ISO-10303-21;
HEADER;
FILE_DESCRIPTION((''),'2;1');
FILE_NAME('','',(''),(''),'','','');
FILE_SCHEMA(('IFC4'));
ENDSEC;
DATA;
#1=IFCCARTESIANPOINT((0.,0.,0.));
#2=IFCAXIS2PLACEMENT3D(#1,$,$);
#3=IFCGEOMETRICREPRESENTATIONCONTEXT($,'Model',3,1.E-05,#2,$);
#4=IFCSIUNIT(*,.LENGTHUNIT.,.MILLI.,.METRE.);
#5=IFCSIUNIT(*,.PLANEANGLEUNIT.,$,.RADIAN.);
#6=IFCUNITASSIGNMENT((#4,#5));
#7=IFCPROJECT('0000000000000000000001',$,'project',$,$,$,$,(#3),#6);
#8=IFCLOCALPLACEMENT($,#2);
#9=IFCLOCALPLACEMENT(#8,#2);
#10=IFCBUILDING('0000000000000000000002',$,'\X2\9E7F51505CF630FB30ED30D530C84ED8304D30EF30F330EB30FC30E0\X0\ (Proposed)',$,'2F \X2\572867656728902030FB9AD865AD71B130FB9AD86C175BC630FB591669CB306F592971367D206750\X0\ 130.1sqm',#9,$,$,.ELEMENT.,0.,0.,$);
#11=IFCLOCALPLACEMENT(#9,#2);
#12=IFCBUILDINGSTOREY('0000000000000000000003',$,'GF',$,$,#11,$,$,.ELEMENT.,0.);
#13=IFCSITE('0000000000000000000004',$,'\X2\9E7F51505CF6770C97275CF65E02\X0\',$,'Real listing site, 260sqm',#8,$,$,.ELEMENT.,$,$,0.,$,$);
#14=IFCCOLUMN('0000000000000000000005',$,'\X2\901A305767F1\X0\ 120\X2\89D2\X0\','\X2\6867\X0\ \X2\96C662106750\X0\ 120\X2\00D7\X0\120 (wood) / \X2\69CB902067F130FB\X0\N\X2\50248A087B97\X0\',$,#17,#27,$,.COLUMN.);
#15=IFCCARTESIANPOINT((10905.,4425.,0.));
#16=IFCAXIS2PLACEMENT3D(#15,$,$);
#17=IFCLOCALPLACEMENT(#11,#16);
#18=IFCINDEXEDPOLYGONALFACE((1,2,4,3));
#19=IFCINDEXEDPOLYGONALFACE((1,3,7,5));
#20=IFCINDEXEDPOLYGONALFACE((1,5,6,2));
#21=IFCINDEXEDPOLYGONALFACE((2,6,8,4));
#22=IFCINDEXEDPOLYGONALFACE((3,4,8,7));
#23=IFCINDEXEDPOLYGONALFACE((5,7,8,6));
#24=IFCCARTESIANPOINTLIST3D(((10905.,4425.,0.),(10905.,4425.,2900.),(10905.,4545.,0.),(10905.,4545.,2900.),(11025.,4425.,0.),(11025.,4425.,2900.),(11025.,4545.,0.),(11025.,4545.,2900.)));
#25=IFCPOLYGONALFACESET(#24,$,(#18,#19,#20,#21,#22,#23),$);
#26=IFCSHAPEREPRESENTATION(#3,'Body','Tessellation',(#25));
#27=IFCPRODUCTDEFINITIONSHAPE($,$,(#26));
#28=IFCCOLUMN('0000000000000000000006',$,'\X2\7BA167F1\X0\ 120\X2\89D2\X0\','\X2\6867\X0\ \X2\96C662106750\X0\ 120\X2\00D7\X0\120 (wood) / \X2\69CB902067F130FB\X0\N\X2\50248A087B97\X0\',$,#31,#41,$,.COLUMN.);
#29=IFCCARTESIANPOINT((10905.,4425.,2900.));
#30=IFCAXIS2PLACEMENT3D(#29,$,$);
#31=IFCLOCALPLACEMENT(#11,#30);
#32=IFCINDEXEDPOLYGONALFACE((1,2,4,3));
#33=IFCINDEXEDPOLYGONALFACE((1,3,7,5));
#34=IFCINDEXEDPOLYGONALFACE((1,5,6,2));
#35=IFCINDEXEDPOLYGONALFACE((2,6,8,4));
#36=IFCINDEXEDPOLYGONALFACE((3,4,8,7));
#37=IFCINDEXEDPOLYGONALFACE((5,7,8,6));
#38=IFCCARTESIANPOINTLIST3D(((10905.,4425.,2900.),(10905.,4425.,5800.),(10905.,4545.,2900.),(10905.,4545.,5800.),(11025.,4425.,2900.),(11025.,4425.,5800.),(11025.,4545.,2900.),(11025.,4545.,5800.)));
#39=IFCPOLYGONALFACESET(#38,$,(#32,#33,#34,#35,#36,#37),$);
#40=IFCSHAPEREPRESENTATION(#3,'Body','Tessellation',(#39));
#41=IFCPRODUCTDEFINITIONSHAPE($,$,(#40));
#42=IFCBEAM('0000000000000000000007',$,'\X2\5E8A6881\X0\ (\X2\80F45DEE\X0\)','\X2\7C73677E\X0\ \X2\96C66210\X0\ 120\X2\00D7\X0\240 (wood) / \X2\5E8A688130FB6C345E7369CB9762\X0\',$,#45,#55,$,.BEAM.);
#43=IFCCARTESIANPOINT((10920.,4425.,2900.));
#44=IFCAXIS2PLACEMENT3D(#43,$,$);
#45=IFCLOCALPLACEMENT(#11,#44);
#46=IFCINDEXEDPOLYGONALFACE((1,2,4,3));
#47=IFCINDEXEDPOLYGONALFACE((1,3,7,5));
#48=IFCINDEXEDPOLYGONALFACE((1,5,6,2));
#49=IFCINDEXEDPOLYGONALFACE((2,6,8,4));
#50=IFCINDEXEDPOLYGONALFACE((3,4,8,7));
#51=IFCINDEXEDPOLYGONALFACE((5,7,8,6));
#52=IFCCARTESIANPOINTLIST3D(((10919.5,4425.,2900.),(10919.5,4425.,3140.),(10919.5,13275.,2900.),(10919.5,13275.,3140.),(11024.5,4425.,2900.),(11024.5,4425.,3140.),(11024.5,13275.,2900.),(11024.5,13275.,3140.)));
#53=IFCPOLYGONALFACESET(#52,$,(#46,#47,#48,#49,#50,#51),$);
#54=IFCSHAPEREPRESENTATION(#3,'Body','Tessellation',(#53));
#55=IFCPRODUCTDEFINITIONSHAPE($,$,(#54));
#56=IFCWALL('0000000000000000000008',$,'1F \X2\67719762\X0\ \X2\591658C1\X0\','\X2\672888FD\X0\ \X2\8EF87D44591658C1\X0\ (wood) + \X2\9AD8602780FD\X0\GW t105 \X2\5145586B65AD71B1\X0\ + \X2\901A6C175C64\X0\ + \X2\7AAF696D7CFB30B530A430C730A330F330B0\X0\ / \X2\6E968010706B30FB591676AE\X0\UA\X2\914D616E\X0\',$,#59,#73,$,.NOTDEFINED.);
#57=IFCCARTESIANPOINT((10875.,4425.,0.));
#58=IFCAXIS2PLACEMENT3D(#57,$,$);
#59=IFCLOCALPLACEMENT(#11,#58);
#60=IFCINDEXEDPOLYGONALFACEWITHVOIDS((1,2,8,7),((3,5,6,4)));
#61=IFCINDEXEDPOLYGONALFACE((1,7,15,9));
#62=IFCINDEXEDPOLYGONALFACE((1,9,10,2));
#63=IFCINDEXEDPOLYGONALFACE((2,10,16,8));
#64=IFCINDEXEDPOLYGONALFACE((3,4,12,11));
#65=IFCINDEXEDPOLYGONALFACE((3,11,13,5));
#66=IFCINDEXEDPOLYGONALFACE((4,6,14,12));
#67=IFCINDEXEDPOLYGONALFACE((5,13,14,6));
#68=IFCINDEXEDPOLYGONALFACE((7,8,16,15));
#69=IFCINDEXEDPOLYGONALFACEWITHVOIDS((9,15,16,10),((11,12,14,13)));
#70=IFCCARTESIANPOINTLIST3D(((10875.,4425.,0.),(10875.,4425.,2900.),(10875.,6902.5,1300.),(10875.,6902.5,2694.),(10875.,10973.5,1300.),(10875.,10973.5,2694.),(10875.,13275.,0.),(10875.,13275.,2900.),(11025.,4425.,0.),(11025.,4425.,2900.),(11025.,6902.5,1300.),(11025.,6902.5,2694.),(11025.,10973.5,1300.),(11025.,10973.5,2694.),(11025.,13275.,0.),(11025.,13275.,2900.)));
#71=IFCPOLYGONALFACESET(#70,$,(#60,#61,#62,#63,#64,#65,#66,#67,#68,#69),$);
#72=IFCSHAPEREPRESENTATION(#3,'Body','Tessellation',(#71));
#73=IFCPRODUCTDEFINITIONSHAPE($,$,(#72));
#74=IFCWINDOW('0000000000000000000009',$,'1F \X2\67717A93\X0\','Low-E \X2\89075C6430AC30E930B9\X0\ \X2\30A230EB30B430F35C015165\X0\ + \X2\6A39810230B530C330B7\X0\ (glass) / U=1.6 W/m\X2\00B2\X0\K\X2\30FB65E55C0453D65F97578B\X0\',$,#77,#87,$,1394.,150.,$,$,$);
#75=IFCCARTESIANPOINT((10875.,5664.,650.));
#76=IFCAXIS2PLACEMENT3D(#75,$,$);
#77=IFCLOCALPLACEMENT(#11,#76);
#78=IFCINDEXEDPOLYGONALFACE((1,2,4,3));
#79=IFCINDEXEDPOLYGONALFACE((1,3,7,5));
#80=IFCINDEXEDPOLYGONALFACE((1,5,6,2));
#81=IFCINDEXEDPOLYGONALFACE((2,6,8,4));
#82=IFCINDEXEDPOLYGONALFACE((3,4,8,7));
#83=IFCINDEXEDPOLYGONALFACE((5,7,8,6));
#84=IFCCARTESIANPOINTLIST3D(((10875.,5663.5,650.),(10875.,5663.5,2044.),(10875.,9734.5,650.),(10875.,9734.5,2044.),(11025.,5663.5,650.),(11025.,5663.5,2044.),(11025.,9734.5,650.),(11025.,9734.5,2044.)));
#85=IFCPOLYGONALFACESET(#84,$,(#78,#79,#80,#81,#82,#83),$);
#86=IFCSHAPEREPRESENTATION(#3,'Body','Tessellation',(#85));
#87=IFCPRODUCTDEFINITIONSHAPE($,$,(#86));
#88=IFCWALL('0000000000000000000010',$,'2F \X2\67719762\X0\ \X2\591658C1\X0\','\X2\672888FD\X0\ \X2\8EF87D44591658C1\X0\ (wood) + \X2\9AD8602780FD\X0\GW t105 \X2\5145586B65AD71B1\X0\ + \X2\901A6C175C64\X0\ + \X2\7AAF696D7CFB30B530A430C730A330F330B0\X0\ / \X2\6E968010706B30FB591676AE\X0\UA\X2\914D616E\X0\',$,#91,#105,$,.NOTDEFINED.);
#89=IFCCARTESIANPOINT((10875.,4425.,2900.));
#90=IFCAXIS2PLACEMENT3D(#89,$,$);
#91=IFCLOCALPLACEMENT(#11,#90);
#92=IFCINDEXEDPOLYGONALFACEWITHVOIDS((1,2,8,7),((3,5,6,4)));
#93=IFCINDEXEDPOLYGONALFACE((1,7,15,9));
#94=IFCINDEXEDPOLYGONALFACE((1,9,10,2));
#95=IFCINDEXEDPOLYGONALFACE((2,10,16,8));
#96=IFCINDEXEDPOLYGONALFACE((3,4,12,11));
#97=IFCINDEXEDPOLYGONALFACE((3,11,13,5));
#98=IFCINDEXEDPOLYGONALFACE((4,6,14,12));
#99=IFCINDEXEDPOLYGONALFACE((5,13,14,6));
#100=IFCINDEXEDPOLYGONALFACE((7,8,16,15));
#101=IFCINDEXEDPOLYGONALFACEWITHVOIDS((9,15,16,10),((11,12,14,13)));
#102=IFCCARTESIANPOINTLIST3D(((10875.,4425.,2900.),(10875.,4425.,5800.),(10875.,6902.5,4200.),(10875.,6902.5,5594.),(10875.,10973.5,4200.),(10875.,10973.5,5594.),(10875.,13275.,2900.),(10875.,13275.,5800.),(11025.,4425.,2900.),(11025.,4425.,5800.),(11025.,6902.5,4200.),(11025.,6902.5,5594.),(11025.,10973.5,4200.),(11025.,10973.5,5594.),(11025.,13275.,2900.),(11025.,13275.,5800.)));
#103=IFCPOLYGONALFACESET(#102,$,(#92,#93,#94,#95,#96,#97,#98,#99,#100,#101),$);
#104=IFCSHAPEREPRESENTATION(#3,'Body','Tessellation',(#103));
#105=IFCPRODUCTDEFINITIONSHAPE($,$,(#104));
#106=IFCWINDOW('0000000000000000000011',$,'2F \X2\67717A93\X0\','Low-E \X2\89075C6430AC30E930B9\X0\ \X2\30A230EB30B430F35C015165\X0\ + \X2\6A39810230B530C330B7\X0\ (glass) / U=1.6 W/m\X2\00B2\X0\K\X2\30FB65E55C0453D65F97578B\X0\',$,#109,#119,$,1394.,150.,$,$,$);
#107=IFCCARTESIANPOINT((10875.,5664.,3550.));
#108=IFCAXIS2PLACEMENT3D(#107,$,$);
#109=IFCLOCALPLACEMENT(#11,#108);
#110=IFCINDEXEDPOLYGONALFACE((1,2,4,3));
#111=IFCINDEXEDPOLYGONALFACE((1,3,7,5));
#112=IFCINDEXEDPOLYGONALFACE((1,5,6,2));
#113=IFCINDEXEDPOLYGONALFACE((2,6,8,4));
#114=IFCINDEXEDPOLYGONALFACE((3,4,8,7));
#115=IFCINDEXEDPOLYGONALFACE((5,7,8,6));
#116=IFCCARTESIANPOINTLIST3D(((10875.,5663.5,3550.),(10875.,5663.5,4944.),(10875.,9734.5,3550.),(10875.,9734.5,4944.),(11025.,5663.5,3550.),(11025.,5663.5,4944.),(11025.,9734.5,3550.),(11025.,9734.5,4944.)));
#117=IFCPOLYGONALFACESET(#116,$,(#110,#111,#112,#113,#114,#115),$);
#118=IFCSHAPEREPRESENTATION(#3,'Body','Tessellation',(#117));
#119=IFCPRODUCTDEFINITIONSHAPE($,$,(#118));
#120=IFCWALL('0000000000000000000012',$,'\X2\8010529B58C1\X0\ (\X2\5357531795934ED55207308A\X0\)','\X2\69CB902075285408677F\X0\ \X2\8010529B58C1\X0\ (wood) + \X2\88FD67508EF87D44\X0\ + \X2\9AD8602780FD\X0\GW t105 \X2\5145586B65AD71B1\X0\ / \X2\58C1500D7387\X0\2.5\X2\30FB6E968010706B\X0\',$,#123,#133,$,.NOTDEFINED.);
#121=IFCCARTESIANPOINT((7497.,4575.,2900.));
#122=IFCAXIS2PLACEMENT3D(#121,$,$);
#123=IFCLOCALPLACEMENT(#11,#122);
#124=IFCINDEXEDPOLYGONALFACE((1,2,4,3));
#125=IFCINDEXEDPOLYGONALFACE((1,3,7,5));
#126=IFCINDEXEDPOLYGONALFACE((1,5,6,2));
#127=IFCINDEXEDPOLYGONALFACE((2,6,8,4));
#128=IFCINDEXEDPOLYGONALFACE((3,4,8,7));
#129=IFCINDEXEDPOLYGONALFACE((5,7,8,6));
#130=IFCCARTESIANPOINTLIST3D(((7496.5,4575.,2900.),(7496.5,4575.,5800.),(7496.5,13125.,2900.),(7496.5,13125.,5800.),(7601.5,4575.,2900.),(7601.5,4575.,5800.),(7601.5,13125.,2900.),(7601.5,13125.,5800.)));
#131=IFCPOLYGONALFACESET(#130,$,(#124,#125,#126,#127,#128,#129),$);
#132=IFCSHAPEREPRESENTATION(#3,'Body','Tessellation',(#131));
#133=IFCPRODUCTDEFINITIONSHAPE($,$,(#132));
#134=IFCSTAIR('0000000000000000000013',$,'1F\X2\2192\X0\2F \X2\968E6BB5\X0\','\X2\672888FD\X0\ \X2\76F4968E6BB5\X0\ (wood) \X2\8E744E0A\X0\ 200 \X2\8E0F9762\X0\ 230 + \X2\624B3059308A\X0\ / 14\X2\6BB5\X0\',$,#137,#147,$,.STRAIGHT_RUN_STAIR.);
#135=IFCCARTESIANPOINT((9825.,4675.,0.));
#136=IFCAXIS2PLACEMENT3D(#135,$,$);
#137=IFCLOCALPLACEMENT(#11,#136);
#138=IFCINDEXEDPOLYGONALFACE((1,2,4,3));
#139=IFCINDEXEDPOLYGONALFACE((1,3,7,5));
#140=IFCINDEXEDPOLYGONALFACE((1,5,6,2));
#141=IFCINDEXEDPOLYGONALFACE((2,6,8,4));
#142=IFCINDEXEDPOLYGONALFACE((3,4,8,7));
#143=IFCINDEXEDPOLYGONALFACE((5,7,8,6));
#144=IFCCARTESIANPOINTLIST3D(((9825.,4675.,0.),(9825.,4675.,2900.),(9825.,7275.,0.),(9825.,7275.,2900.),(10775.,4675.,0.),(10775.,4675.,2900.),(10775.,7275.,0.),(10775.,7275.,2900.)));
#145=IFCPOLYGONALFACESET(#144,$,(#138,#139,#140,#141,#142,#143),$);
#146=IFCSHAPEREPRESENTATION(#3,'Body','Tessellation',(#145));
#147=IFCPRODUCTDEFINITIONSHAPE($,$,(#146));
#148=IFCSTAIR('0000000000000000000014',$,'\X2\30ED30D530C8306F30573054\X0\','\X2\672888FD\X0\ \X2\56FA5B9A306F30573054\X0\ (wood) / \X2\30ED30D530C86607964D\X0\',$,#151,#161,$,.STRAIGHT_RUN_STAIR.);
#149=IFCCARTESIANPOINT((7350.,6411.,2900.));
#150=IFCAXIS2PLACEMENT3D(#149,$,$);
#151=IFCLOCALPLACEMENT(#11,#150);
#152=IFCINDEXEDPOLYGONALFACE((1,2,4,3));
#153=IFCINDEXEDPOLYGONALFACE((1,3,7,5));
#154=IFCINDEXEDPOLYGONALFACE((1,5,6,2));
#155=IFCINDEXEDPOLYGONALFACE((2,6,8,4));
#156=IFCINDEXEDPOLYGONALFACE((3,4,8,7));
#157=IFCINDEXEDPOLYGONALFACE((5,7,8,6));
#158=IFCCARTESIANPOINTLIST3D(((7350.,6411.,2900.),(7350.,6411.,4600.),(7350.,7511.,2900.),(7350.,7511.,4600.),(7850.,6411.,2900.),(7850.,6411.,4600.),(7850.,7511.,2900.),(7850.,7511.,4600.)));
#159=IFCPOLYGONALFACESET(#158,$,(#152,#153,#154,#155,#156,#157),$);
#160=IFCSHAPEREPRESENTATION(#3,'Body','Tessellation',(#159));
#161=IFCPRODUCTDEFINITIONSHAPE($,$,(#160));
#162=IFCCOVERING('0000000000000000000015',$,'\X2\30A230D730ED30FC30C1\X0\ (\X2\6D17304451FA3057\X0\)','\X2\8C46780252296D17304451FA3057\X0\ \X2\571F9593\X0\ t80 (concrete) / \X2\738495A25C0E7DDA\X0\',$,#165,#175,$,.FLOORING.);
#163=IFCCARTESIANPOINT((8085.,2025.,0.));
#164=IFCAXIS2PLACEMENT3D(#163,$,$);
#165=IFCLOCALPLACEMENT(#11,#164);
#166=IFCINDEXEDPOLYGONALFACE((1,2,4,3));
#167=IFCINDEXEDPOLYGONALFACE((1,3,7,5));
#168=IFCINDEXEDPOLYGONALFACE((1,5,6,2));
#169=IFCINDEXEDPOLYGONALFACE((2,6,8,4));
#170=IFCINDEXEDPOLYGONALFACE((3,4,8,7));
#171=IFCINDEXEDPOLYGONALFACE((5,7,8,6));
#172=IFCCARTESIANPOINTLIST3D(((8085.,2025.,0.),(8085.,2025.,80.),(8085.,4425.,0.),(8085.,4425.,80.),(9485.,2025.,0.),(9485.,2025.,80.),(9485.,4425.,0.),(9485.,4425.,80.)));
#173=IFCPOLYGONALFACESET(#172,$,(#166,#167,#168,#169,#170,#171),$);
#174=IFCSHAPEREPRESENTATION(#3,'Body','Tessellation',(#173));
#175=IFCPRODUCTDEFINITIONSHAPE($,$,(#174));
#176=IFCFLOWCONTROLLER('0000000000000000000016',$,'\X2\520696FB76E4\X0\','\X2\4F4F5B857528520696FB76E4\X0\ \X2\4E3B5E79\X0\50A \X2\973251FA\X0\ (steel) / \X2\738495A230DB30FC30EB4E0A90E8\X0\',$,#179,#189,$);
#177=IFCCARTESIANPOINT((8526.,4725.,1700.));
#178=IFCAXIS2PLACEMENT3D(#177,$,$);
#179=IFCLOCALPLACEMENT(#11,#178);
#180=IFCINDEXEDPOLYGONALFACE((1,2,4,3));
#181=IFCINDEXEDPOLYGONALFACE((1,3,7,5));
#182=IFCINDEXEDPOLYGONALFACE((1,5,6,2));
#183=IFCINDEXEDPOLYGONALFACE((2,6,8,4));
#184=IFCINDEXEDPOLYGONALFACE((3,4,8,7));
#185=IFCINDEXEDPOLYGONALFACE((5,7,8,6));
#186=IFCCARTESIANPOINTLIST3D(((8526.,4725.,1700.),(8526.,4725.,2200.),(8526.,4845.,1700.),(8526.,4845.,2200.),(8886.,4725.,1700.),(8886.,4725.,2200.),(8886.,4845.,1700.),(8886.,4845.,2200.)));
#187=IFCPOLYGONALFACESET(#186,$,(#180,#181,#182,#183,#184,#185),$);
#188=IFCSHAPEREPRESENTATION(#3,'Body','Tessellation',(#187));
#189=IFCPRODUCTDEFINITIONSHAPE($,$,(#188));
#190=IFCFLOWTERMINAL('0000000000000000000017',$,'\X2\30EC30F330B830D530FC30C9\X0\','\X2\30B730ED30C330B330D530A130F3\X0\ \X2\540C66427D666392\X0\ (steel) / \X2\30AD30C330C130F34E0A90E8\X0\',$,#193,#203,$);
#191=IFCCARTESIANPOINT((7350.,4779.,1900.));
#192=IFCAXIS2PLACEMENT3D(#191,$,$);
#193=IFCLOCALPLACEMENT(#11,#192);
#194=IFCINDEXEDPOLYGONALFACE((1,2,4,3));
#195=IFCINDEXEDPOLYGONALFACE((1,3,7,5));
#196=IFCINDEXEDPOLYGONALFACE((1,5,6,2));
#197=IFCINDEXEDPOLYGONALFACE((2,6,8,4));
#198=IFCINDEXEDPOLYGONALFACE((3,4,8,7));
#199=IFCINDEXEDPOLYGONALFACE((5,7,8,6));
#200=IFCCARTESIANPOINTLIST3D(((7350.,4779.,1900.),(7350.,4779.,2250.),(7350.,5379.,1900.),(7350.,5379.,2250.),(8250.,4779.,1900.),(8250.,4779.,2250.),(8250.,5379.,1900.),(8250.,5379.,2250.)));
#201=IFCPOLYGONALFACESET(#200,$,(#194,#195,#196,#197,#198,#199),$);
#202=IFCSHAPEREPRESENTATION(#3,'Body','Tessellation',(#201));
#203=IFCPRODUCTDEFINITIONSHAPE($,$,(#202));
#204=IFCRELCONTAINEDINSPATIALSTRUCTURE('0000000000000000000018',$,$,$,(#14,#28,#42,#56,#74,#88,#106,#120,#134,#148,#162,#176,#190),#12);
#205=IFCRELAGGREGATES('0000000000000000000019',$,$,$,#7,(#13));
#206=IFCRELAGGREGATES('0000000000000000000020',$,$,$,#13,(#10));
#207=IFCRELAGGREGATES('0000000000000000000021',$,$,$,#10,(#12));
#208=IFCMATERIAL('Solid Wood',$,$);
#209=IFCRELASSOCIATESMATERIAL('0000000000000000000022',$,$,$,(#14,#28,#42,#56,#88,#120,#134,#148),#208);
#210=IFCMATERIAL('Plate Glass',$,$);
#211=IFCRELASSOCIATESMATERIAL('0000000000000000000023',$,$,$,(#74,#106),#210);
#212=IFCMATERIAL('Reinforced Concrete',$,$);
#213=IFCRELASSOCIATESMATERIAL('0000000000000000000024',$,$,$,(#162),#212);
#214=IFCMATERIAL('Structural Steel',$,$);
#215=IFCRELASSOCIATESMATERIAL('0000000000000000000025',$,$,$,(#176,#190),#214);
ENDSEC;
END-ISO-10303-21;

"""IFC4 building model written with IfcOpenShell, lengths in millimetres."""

from ifc_helpers import new_model, si_unit, frame, frame_2d, origin, place, context, project, spatial, rectangle, extrude, material, element, fill, save


model = new_model("IFC4")

# Units and contexts
model_context = context("Model", 3, precision=1e-05, world=origin())
ifc_project = project(units=[si_unit("LENGTHUNIT", "METRE", prefix="MILLI"), si_unit("PLANEANGLEUNIT", "RADIAN")], contexts=[model_context])

# Site, building, storey
site_placement = place(None, origin())
site = spatial("IfcSite", under=ifc_project, at=site_placement, Name="鹿児島県霧島市", ObjectType="Real listing site, 260sqm", CompositionType="ELEMENT", RefElevation=0.0)
building_placement = place(site_placement, origin())
building = spatial("IfcBuilding", under=site, at=building_placement, Name="鹿児島・ロフト付きワンルーム (Proposed)", ObjectType="2F 在来木造・高断熱・高気密・外構は天然素材 130.1sqm", CompositionType="ELEMENT", ElevationOfRefHeight=0.0, ElevationOfTerrain=0.0)
storey_placement = place(building_placement, origin())
storey = spatial("IfcBuildingStorey", under=building, at=storey_placement, Name="GF", CompositionType="ELEMENT", Elevation=0.0)

# Columns
ifc_material_1 = material(Name="Solid Wood")
column_1_placement = place(storey_placement, frame((10905.0, 4425.0, 0.0)))
element("IfcColumn", 1, at=column_1_placement, inside=storey, material=ifc_material_1, Name="通し柱 120角", Description="桧 集成材 120×120 (wood) / 構造柱・N値計算", PredefinedType="COLUMN", context=model_context, shape_type="SweptSolid", body=[
    extrude(rectangle(XDim=120.0, YDim=120.0, at=frame_2d((60.0, 60.0))), frame((10905.0, 4425.0, 0.0)), (0.0, 0.0, 1.0), 2900.0),
])
column_2_placement = place(storey_placement, frame((10905.0, 4425.0, 2900.0)))
element("IfcColumn", 2, at=column_2_placement, inside=storey, material=ifc_material_1, Name="管柱 120角", Description="桧 集成材 120×120 (wood) / 構造柱・N値計算", PredefinedType="COLUMN", context=model_context, shape_type="SweptSolid", body=[
    extrude(rectangle(XDim=120.0, YDim=120.0, at=frame_2d((60.0, 60.0))), frame((10905.0, 4425.0, 2900.0)), (0.0, 0.0, 1.0), 2900.0),
])

# Beam
beam_1_placement = place(storey_placement, frame((10920.0, 4425.0, 2900.0)))
element("IfcBeam", 3, at=beam_1_placement, inside=storey, material=ifc_material_1, Name="床梁 (胴差)", Description="米松 集成 120×240 (wood) / 床梁・水平構面", PredefinedType="BEAM", context=model_context, shape_type="SweptSolid", body=[
    extrude(rectangle(XDim=105.0, YDim=8850.0, at=frame_2d((52.0, 4425.0))), frame((10920.0, 4425.0, 2900.0)), (0.0, 0.0, 1.0), 240.0),
])

# Wall, opening, window
wall_1_placement = place(storey_placement, frame((10875.0, 4425.0, 0.0)))
wall_1 = element("IfcWall", 4, at=wall_1_placement, inside=storey, material=ifc_material_1, Name="1F 東面 外壁", Description="木製 軸組外壁 (wood) + 高性能GW t105 充填断熱 + 通気層 + 窯業系サイディング / 準耐火・外皮UA配慮", PredefinedType="NOTDEFINED", context=model_context, shape_type="SweptSolid", body=[
    extrude(rectangle(XDim=150.0, YDim=8850.0, at=frame_2d((75.0, 4425.0))), frame((10875.0, 4425.0, 0.0)), (0.0, 0.0, 1.0), 2900.0),
])
opening_1_placement = place(storey_placement, frame((10875.0, 5664.0, 650.0)))
opening_1 = element("IfcOpeningElement", 5, at=opening_1_placement, cuts=wall_1, PredefinedType="NOTDEFINED", context=model_context, shape_type="SweptSolid", body=[
    extrude(rectangle(XDim=150.0, YDim=4071.0, at=frame_2d((75.0, 2035.0))), frame((10875.0, 5664.0, 650.0)), (0.0, 0.0, 1.0), 1394.0),
])
ifc_material_2 = material(Name="Plate Glass")
window_1_placement = place(storey_placement, frame((10875.0, 5664.0, 650.0)))
window_1 = element("IfcWindow", 6, at=window_1_placement, inside=storey, material=ifc_material_2, Name="1F 東窓", Description="Low-E 複層ガラス アルゴン封入 + 樹脂サッシ (glass) / U=1.6 W/m²K・日射取得型", OverallHeight=1394.0, OverallWidth=150.0, context=model_context, shape_type="SweptSolid", body=[
    extrude(rectangle(XDim=150.0, YDim=4071.0, at=frame_2d((75.0, 2035.0))), frame((10875.0, 5664.0, 650.0)), (0.0, 0.0, 1.0), 1394.0),
])
fill(opening_1, window_1)

# Wall, opening, window
wall_2_placement = place(storey_placement, frame((10875.0, 4425.0, 2900.0)))
wall_2 = element("IfcWall", 7, at=wall_2_placement, inside=storey, material=ifc_material_1, Name="2F 東面 外壁", Description="木製 軸組外壁 (wood) + 高性能GW t105 充填断熱 + 通気層 + 窯業系サイディング / 準耐火・外皮UA配慮", PredefinedType="NOTDEFINED", context=model_context, shape_type="SweptSolid", body=[
    extrude(rectangle(XDim=150.0, YDim=8850.0, at=frame_2d((75.0, 4425.0))), frame((10875.0, 4425.0, 2900.0)), (0.0, 0.0, 1.0), 2900.0),
])
opening_2_placement = place(storey_placement, frame((10875.0, 5664.0, 3550.0)))
opening_2 = element("IfcOpeningElement", 8, at=opening_2_placement, cuts=wall_2, PredefinedType="NOTDEFINED", context=model_context, shape_type="SweptSolid", body=[
    extrude(rectangle(XDim=150.0, YDim=4071.0, at=frame_2d((75.0, 2035.0))), frame((10875.0, 5664.0, 3550.0)), (0.0, 0.0, 1.0), 1394.0),
])
window_2_placement = place(storey_placement, frame((10875.0, 5664.0, 3550.0)))
window_2 = element("IfcWindow", 9, at=window_2_placement, inside=storey, material=ifc_material_2, Name="2F 東窓", Description="Low-E 複層ガラス アルゴン封入 + 樹脂サッシ (glass) / U=1.6 W/m²K・日射取得型", OverallHeight=1394.0, OverallWidth=150.0, context=model_context, shape_type="SweptSolid", body=[
    extrude(rectangle(XDim=150.0, YDim=4071.0, at=frame_2d((75.0, 2035.0))), frame((10875.0, 5664.0, 3550.0)), (0.0, 0.0, 1.0), 1394.0),
])
fill(opening_2, window_2)

# Wall
wall_3_placement = place(storey_placement, frame((7497.0, 4575.0, 2900.0)))
element("IfcWall", 10, at=wall_3_placement, inside=storey, material=ifc_material_1, Name="耐力壁 (南北間仕切り)", Description="構造用合板 耐力壁 (wood) + 製材軸組 + 高性能GW t105 充填断熱 / 壁倍率2.5・準耐火", PredefinedType="NOTDEFINED", context=model_context, shape_type="SweptSolid", body=[
    extrude(rectangle(XDim=105.0, YDim=8550.0, at=frame_2d((52.0, 4275.0))), frame((7497.0, 4575.0, 2900.0)), (0.0, 0.0, 1.0), 2900.0),
])

# Stairs
stair_1_placement = place(storey_placement, frame((9825.0, 4675.0, 0.0)))
element("IfcStair", 11, at=stair_1_placement, inside=storey, material=ifc_material_1, Name="1F→2F 階段", Description="木製 直階段 (wood) 蹴上 200 踏面 230 + 手すり / 14段", PredefinedType="STRAIGHT_RUN_STAIR", context=model_context, shape_type="SweptSolid", body=[
    extrude(rectangle(XDim=950.0, YDim=2600.0, at=frame_2d((475.0, 1300.0))), frame((9825.0, 4675.0, 0.0)), (0.0, 0.0, 1.0), 2900.0),
])
stair_2_placement = place(storey_placement, frame((7350.0, 6411.0, 2900.0)))
element("IfcStair", 12, at=stair_2_placement, inside=storey, material=ifc_material_1, Name="ロフトはしご", Description="木製 固定はしご (wood) / ロフト昇降", PredefinedType="STRAIGHT_RUN_STAIR", context=model_context, shape_type="SweptSolid", body=[
    extrude(rectangle(XDim=500.0, YDim=1100.0, at=frame_2d((250.0, 550.0))), frame((7350.0, 6411.0, 2900.0)), (0.0, 0.0, 1.0), 1700.0),
])

# Covering
ifc_material_3 = material(Name="Reinforced Concrete")
covering_placement = place(storey_placement, frame((8085.0, 2025.0, 0.0)))
element("IfcCovering", 13, at=covering_placement, inside=storey, material=ifc_material_3, Name="アプローチ (洗い出し)", Description="豆砂利洗い出し 土間 t80 (concrete) / 玄関導線", PredefinedType="FLOORING", context=model_context, shape_type="SweptSolid", body=[
    extrude(rectangle(XDim=1400.0, YDim=2400.0, at=frame_2d((700.0, 1200.0))), frame((8085.0, 2025.0, 0.0)), (0.0, 0.0, 1.0), 80.0),
])

# Flow controller
ifc_material_4 = material(Name="Structural Steel")
flow_controller_placement = place(storey_placement, frame((8526.0, 4725.0, 1700.0)))
element("IfcFlowController", 14, at=flow_controller_placement, inside=storey, material=ifc_material_4, Name="分電盤", Description="住宅用分電盤 主幹50A 露出 (steel) / 玄関ホール上部", context=model_context, shape_type="SweptSolid", body=[
    extrude(rectangle(XDim=360.0, YDim=120.0, at=frame_2d((180.0, 60.0))), frame((8526.0, 4725.0, 1700.0)), (0.0, 0.0, 1.0), 500.0),
])

# Flow terminal
flow_terminal_1_placement = place(storey_placement, frame((7350.0, 4779.0, 1900.0)))
element("IfcFlowTerminal", 15, at=flow_terminal_1_placement, inside=storey, material=ifc_material_4, Name="レンジフード", Description="シロッコファン 同時給排 (steel) / キッチン上部", context=model_context, shape_type="SweptSolid", body=[
    extrude(rectangle(XDim=900.0, YDim=600.0, at=frame_2d((450.0, 300.0))), frame((7350.0, 4779.0, 1900.0)), (0.0, 0.0, 1.0), 350.0),
])

save(model, "model.ifc")
